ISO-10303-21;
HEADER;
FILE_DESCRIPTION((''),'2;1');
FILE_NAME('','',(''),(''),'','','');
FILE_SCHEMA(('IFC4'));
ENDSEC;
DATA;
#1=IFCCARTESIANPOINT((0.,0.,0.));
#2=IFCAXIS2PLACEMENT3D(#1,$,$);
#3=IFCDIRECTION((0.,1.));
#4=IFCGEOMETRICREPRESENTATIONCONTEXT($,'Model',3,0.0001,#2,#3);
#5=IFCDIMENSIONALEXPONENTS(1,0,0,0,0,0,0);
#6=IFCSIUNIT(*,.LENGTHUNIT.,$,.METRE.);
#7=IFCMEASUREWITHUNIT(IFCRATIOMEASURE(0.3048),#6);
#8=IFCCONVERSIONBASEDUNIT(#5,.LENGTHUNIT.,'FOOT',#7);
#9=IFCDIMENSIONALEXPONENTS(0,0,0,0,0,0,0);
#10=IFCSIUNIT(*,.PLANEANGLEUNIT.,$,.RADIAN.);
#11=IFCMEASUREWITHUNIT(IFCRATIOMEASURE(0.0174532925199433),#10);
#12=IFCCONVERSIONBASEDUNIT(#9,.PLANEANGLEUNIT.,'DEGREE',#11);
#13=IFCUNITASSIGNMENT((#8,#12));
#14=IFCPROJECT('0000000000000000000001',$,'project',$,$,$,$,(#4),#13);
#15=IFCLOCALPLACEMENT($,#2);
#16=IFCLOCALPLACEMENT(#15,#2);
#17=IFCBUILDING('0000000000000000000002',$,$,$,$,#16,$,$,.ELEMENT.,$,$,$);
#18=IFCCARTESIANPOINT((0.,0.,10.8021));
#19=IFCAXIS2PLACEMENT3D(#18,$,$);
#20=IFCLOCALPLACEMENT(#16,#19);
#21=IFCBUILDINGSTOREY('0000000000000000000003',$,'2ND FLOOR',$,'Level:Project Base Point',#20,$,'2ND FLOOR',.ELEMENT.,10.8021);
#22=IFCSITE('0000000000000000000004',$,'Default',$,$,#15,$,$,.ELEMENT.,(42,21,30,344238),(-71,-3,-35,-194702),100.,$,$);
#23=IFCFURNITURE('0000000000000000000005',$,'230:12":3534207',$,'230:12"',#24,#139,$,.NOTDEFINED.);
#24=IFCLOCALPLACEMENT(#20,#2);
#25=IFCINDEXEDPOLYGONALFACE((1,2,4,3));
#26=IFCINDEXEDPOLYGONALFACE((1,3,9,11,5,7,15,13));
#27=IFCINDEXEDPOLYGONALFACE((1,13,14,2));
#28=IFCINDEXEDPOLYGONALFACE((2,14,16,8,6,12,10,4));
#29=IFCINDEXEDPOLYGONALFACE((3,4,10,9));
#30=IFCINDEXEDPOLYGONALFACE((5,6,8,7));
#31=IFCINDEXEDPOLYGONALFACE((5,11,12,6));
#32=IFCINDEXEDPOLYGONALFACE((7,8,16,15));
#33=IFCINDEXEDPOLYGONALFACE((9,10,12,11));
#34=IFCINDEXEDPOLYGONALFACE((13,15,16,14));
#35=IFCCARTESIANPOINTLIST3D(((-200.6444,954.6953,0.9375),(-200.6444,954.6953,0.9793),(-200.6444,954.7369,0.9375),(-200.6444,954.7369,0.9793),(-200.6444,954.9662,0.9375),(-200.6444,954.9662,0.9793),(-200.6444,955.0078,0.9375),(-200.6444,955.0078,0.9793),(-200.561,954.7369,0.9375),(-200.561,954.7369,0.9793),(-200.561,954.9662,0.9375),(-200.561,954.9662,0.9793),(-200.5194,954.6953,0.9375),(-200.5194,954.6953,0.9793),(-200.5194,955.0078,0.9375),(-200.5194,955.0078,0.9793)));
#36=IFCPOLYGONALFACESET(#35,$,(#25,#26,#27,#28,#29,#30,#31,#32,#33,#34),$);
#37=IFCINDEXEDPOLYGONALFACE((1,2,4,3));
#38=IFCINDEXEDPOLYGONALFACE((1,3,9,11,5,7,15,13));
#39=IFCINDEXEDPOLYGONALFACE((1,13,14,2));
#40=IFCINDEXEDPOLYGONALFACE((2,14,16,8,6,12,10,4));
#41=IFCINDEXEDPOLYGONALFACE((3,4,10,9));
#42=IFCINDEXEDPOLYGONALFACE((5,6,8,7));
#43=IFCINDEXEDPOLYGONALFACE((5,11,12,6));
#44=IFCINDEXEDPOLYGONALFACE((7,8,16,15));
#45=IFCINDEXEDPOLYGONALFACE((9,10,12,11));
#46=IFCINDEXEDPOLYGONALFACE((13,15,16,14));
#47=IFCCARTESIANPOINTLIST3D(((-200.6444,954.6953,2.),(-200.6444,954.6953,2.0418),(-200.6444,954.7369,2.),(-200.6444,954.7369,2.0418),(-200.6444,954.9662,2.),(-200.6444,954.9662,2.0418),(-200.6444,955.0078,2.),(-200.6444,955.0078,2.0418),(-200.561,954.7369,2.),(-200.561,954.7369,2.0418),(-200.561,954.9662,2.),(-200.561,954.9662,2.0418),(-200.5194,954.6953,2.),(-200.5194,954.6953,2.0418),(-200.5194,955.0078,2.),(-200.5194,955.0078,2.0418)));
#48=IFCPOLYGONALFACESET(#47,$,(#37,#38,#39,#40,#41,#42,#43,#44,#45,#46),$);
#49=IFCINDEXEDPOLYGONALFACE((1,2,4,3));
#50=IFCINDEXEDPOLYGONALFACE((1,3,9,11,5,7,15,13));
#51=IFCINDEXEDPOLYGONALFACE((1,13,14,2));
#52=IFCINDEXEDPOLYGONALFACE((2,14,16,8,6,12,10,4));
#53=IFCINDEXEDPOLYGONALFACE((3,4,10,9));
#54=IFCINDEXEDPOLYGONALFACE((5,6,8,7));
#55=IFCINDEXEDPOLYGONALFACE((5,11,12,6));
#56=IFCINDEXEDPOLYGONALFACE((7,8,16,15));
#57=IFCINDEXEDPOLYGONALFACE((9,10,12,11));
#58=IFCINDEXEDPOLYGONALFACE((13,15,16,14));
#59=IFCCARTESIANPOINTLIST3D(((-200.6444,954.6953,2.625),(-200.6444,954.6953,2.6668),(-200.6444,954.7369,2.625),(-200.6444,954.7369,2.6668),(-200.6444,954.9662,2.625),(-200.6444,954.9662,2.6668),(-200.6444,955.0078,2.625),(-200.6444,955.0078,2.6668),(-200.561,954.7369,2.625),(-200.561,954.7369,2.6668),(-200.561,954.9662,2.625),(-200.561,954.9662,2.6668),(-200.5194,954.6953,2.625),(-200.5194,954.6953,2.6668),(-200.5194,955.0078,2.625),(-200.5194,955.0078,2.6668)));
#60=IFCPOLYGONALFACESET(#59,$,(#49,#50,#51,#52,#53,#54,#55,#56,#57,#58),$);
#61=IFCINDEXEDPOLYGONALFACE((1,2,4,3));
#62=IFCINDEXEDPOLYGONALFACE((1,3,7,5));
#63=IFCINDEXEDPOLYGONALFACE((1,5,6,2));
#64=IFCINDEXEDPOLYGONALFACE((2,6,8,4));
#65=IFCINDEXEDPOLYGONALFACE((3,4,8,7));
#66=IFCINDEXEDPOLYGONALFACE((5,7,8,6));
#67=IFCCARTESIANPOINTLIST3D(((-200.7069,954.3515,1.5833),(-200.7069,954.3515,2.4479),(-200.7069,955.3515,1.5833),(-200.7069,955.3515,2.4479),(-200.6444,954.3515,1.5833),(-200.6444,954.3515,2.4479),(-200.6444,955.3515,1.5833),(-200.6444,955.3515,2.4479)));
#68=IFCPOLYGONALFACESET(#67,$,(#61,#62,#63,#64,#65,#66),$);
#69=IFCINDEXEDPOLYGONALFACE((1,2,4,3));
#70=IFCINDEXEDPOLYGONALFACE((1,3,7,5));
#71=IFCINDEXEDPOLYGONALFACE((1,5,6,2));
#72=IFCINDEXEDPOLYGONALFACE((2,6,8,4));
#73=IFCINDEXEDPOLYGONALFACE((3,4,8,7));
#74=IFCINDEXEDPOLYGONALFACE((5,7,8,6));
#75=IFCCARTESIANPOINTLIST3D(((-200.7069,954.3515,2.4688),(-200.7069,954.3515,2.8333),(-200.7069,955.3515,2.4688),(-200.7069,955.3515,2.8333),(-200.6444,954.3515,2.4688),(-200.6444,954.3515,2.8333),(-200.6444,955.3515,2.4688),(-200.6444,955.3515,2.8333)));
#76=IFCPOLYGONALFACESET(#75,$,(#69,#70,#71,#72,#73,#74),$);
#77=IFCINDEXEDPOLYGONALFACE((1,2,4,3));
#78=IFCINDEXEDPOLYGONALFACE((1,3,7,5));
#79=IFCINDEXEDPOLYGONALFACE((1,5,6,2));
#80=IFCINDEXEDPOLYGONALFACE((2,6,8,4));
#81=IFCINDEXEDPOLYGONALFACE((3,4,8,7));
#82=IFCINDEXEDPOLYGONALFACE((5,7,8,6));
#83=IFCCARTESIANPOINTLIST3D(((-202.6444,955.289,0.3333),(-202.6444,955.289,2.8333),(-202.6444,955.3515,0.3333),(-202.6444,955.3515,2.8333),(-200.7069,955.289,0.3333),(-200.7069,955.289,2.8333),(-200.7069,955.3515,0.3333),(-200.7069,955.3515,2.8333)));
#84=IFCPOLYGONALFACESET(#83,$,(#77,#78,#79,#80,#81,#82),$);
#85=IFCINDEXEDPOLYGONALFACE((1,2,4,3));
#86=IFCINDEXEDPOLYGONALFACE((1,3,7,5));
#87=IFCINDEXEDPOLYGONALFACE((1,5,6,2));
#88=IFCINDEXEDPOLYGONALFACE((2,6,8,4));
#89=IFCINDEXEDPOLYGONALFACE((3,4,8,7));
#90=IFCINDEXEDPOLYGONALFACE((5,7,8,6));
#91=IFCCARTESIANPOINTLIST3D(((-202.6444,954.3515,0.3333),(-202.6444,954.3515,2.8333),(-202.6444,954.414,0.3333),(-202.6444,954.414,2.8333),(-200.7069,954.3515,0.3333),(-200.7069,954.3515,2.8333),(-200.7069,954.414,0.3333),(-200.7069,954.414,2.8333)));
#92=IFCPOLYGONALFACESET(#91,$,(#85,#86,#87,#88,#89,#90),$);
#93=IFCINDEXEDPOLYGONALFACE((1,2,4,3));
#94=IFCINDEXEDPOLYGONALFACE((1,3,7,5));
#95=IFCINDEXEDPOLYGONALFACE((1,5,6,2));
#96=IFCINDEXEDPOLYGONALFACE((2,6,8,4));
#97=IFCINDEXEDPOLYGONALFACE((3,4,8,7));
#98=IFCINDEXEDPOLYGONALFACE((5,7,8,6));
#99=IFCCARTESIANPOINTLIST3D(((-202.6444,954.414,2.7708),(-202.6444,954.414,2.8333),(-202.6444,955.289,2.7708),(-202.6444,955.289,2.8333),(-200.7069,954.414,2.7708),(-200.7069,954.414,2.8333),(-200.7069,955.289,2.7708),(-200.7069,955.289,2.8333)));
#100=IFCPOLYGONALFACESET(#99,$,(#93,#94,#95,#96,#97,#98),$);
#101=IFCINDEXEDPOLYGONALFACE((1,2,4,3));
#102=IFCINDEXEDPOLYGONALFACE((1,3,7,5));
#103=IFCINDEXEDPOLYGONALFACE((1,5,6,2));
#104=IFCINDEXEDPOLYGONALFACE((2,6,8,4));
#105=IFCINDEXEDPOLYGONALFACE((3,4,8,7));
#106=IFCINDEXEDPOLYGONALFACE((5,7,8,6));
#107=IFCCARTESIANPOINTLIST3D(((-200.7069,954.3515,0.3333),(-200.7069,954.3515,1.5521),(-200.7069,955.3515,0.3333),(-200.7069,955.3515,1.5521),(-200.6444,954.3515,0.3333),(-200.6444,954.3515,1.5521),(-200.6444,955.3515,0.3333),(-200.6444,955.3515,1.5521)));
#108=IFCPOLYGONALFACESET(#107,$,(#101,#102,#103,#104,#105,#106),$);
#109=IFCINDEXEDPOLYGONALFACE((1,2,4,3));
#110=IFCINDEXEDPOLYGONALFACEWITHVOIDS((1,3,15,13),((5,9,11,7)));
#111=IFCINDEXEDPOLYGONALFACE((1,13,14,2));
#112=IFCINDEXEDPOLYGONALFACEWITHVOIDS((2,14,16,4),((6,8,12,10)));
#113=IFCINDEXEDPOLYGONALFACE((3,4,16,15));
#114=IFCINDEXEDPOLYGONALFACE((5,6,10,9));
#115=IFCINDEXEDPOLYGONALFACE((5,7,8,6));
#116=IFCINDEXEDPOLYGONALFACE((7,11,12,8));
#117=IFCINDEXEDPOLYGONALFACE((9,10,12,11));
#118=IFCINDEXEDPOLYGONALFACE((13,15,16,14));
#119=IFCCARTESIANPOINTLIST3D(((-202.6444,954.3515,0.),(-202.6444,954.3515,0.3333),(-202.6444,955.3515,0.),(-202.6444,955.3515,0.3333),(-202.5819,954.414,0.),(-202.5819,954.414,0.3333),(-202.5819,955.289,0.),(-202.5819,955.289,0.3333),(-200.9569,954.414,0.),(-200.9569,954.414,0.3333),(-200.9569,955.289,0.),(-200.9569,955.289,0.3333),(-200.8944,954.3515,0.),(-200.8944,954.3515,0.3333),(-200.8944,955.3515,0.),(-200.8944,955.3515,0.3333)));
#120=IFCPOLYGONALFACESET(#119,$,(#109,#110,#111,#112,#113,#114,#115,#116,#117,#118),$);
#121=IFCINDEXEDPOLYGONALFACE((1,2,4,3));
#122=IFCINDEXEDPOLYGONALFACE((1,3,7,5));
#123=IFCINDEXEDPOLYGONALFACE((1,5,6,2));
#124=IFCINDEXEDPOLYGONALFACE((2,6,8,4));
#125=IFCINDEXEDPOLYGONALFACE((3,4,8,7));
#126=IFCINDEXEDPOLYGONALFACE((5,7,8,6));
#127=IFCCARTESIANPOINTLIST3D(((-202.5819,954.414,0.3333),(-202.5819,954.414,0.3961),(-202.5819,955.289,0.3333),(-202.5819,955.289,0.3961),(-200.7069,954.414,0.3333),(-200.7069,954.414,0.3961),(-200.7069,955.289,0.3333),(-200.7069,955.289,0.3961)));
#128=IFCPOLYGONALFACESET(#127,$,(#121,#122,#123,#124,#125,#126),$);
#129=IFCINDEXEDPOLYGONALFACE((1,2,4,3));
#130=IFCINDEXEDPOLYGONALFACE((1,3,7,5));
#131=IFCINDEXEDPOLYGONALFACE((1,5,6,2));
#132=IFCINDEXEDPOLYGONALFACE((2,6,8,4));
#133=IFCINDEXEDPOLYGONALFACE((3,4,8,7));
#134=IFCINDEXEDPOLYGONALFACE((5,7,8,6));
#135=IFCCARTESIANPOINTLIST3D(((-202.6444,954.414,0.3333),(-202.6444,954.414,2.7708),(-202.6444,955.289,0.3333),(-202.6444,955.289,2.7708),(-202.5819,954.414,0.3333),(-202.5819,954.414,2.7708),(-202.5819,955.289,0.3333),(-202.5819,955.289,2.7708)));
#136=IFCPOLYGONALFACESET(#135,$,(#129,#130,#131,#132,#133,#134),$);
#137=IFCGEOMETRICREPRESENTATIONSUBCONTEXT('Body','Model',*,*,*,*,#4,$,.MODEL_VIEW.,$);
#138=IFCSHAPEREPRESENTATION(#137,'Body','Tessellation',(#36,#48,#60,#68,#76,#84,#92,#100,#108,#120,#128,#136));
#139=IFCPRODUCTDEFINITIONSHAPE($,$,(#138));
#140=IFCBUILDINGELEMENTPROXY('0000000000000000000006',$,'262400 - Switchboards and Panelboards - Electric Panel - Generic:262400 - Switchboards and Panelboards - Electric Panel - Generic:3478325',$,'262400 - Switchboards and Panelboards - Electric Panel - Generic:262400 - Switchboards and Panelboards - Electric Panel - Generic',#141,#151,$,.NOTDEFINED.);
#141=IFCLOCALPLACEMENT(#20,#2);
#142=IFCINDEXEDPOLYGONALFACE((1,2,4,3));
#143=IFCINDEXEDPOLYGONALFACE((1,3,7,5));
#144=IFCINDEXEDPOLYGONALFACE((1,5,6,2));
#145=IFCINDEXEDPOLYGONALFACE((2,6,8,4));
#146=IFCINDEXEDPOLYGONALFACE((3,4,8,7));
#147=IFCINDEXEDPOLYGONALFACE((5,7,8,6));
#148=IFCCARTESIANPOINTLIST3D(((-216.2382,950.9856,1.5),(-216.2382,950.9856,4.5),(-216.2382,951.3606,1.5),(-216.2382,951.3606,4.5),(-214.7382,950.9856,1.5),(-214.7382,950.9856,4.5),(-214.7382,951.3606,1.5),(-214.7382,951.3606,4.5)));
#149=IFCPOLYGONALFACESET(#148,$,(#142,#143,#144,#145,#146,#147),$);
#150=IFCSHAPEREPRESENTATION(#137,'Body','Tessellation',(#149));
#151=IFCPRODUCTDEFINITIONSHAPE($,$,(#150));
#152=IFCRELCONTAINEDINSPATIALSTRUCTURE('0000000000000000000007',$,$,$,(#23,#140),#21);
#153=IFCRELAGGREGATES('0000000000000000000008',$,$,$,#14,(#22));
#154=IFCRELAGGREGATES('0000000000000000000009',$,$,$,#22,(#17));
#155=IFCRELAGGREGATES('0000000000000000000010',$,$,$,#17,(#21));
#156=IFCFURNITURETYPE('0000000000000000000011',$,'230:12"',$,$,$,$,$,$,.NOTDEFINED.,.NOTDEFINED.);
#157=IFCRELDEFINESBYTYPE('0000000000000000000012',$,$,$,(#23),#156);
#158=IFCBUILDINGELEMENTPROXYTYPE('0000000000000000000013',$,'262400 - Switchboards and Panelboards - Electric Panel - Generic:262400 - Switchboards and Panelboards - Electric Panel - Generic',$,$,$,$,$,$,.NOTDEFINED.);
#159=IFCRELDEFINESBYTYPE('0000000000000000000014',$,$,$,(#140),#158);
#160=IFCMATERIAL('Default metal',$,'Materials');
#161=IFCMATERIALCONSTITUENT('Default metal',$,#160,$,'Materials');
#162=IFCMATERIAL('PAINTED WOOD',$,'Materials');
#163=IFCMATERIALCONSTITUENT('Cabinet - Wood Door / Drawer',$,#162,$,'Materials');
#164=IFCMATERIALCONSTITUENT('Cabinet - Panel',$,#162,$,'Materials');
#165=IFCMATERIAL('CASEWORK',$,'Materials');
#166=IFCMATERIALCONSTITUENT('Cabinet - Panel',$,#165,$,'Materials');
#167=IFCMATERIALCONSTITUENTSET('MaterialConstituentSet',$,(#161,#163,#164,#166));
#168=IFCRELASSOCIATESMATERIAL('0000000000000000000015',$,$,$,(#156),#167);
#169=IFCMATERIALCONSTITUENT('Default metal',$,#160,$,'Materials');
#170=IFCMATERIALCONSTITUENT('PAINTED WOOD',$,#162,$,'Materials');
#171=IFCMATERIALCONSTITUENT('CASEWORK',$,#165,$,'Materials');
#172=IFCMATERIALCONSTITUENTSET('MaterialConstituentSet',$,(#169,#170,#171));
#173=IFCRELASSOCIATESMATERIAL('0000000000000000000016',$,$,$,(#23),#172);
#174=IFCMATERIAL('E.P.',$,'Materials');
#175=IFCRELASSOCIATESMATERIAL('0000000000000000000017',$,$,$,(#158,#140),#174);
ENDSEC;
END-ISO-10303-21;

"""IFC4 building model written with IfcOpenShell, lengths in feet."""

from ifc_helpers import new_model, entity, si_unit, converted_unit, direction, frame, frame_2d, origin, origin_2d_with_axis, place, context, subcontext, project, spatial, polyline, rectangle, outline, extrude, source, transform, mapped, material, constituent, constituent_set, type_object, type_shapes, element, save


model = new_model("IFC4")

# Units and contexts
model_context = context("Model", 3, precision=0.0001, world=origin(), true_north=direction((0.0, 1.0)))
body_context = subcontext(model_context, "Body", "Model", "MODEL_VIEW")
ifc_project = project(units=[converted_unit("LENGTHUNIT", "FOOT", entity("IfcRatioMeasure", 0.3048), si_unit("LENGTHUNIT", "METRE"), dimensions=[1, 0, 0, 0, 0, 0, 0]), converted_unit("PLANEANGLEUNIT", "DEGREE", entity("IfcRatioMeasure", 0.0174532925199433), si_unit("PLANEANGLEUNIT", "RADIAN"), dimensions=[0, 0, 0, 0, 0, 0, 0])], contexts=[model_context])

# Site, building, storey
site_placement = place(None, origin())
site = spatial("IfcSite", under=ifc_project, at=site_placement, Name="Default", CompositionType="ELEMENT", RefLatitude=(42, 21, 30, 344238), RefLongitude=(-71, -3, -35, -194702), RefElevation=100.0)
building_placement = place(site_placement, origin())
building = spatial("IfcBuilding", under=site, at=building_placement, CompositionType="ELEMENT")
storey_placement = place(building_placement, frame((0.0, 0.0, 10.8021)))
storey = spatial("IfcBuildingStorey", under=building, at=storey_placement, Name="2ND FLOOR", ObjectType="Level:Project Base Point", LongName="2ND FLOOR", CompositionType="ELEMENT", Elevation=10.8021)

# Furniture
ifc_material_1 = material(Name="CASEWORK", Category="Materials")
ifc_material_2 = material(Name="PAINTED WOOD", Category="Materials")
ifc_material_3 = material(Name="Default metal", Category="Materials")
ifc_constituent_1 = constituent(ifc_material_3, Name="Default metal", Category="Materials")
ifc_constituent_2 = constituent(ifc_material_2, Name="PAINTED WOOD", Category="Materials")
ifc_constituent_3 = constituent(ifc_material_1, Name="CASEWORK", Category="Materials")
ifc_constituent_set_1 = constituent_set(constituents=[ifc_constituent_1, ifc_constituent_2, ifc_constituent_3], Name="MaterialConstituentSet")
ifc_constituent_4 = constituent(ifc_material_3, Name="Default metal", Category="Materials")
ifc_constituent_5 = constituent(ifc_material_2, Name="Cabinet - Wood Door / Drawer", Category="Materials")
ifc_constituent_6 = constituent(ifc_material_2, Name="Cabinet - Panel", Category="Materials")
ifc_constituent_7 = constituent(ifc_material_1, Name="Cabinet - Panel", Category="Materials")
ifc_constituent_set_2 = constituent_set(constituents=[ifc_constituent_4, ifc_constituent_5, ifc_constituent_6, ifc_constituent_7], Name="MaterialConstituentSet")
furniture_type_1 = type_object("IfcFurnitureType", Name="230:12\"", AssemblyPlace="NOTDEFINED", PredefinedType="NOTDEFINED", material=ifc_constituent_set_2)
shared_shape_1 = source(origin(), body_context, "Body", "SweptSolid", [
    extrude(outline(polyline([(-0.1562, -0.0521), (-0.1146, -0.0521), (-0.1146, 0.0313), (0.1146, 0.0313), (0.1146, -0.0521), (0.1562, -0.0521), (0.1562, 0.0729), (-0.1562, 0.0729), (-0.1562, -0.0521)])), frame((0.0615, 2.0521, 0.9375)), (0.0, 0.0, 1.0), 0.0418),
    extrude(outline(polyline([(-0.1562, -0.0521), (-0.1146, -0.0521), (-0.1146, 0.0313), (0.1146, 0.0313), (0.1146, -0.0521), (0.1562, -0.0521), (0.1562, 0.0729), (-0.1562, 0.0729), (-0.1562, -0.0521)])), frame((0.0615, 2.0521, 2.0)), (0.0, 0.0, 1.0), 0.0418),
    extrude(outline(polyline([(-0.1562, -0.0521), (-0.1146, -0.0521), (-0.1146, 0.0313), (0.1146, 0.0313), (0.1146, -0.0521), (0.1562, -0.0521), (0.1562, 0.0729), (-0.1562, 0.0729), (-0.1562, -0.0521)])), frame((0.0615, 2.0521, 2.625)), (0.0, 0.0, 1.0), 0.0418),
    extrude(rectangle(XDim=1.0, YDim=0.0625, at=origin_2d_with_axis()), frame((0.0615, 1.9688, 1.5833), z_axis=(0.0, 0.0, 1.0), x_axis=(-1.0, 0.0, 0.0)), (0.0, 0.0, 1.0), 0.8646),
    extrude(rectangle(XDim=1.0, YDim=0.0625, at=origin_2d_with_axis()), frame((0.0615, 1.9688, 2.4688), z_axis=(0.0, 0.0, 1.0), x_axis=(-1.0, 0.0, 0.0)), (0.0, 0.0, 1.0), 0.3646),
    extrude(rectangle(XDim=1.9375, YDim=0.0625, at=frame_2d((0.0, 0.0), x_axis=(1.0, 0.0))), frame((-0.4073, 0.9687, 0.3333), z_axis=(0.0, 0.0, 1.0), x_axis=(0.0, -1.0, 0.0)), (0.0, 0.0, 1.0), 2.5),
    extrude(rectangle(XDim=1.9375, YDim=0.0625, at=frame_2d((0.0, 0.0), x_axis=(1.0, 0.0))), frame((0.5302, 0.9687, 0.3333), z_axis=(0.0, 0.0, 1.0), x_axis=(0.0, -1.0, 0.0)), (0.0, 0.0, 1.0), 2.5),
    extrude(rectangle(XDim=1.9375, YDim=0.875, at=origin_2d_with_axis()), frame((0.0615, 0.9687, 2.7708), z_axis=(0.0, 0.0, 1.0), x_axis=(0.0, 1.0, 0.0)), (0.0, 0.0, 1.0), 0.0625),
    extrude(rectangle(XDim=1.0, YDim=0.0625, at=origin_2d_with_axis()), frame((0.0615, 1.9688, 0.3333), z_axis=(0.0, 0.0, 1.0), x_axis=(-1.0, 0.0, 0.0)), (0.0, 0.0, 1.0), 1.2187),
    extrude(outline(polyline([(-0.875, -0.5), (0.875, -0.5), (0.875, 0.5), (-0.875, 0.5), (-0.875, -0.5)]), holes=[polyline([(-0.8125, -0.4375), (-0.8125, 0.4375), (0.8125, 0.4375), (0.8125, -0.4375), (-0.8125, -0.4375)])]), frame((0.0615, 0.875, 0.0), z_axis=(0.0, 0.0, 1.0), x_axis=(0.0, -1.0, 0.0)), (0.0, 0.0, 1.0), 0.3333),
    extrude(rectangle(XDim=1.875, YDim=0.875, at=origin_2d_with_axis()), frame((0.0615, 1.0, 0.3333), z_axis=(0.0, 0.0, 1.0), x_axis=(0.0, 1.0, 0.0)), (0.0, 0.0, 1.0), 0.0627),
    extrude(rectangle(XDim=0.875, YDim=0.0625, at=origin_2d_with_axis()), frame((0.0615, 0.0312, 0.3333), z_axis=(0.0, 0.0, 1.0), x_axis=(-1.0, 0.0, 0.0)), (0.0, 0.0, 1.0), 2.4375),
])
type_shapes(furniture_type_1, [shared_shape_1])
furniture_1_placement = place(storey_placement, frame((-202.6444, 954.913, 0.0), z_axis=(0.0, 0.0, 1.0), x_axis=(0.0, -1.0, 0.0)))
element("IfcFurniture", 1, at=furniture_1_placement, inside=storey, type_object=furniture_type_1, material=ifc_constituent_set_1, Name="230:12\":3534207", ObjectType="230:12\"", PredefinedType="NOTDEFINED", context=body_context, shape_type="MappedRepresentation", body=[
    mapped(shared_shape_1, transform((0.0, 0.0, 0.0), scale=1.0)),
])

# Building element proxy
ifc_material_4 = material(Name="E.P.", Category="Materials")
building_element_proxy_type_1 = type_object("IfcBuildingElementProxyType", Name="262400 - Switchboards and Panelboards - Electric Panel - Generic:262400 - Switchboards and Panelboards - Electric Panel - Generic", PredefinedType="NOTDEFINED", material=ifc_material_4)
shared_shape_2 = source(origin(), body_context, "Body", "SweptSolid", [
    extrude(rectangle(XDim=1.5, YDim=0.375, at=origin_2d_with_axis()), frame((0.75, 0.1875, 0.0), z_axis=(0.0, 0.0, 1.0), x_axis=(-1.0, 0.0, 0.0)), (0.0, 0.0, 1.0), 3.0),
])
type_shapes(building_element_proxy_type_1, [shared_shape_2])
proxy_1_placement = place(storey_placement, frame((-214.7382, 951.3606, 1.5), z_axis=(0.0, 0.0, 1.0), x_axis=(-1.0, 0.0, 0.0)))
element("IfcBuildingElementProxy", 2, at=proxy_1_placement, inside=storey, type_object=building_element_proxy_type_1, material=ifc_material_4, Name="262400 - Switchboards and Panelboards - Electric Panel - Generic:262400 - Switchboards and Panelboards - Electric Panel - Generic:3478325", ObjectType="262400 - Switchboards and Panelboards - Electric Panel - Generic:262400 - Switchboards and Panelboards - Electric Panel - Generic", PredefinedType="NOTDEFINED", context=body_context, shape_type="MappedRepresentation", body=[
    mapped(shared_shape_2, transform((0.0, 0.0, 0.0), scale=1.0)),
])

save(model, "model.ifc")
